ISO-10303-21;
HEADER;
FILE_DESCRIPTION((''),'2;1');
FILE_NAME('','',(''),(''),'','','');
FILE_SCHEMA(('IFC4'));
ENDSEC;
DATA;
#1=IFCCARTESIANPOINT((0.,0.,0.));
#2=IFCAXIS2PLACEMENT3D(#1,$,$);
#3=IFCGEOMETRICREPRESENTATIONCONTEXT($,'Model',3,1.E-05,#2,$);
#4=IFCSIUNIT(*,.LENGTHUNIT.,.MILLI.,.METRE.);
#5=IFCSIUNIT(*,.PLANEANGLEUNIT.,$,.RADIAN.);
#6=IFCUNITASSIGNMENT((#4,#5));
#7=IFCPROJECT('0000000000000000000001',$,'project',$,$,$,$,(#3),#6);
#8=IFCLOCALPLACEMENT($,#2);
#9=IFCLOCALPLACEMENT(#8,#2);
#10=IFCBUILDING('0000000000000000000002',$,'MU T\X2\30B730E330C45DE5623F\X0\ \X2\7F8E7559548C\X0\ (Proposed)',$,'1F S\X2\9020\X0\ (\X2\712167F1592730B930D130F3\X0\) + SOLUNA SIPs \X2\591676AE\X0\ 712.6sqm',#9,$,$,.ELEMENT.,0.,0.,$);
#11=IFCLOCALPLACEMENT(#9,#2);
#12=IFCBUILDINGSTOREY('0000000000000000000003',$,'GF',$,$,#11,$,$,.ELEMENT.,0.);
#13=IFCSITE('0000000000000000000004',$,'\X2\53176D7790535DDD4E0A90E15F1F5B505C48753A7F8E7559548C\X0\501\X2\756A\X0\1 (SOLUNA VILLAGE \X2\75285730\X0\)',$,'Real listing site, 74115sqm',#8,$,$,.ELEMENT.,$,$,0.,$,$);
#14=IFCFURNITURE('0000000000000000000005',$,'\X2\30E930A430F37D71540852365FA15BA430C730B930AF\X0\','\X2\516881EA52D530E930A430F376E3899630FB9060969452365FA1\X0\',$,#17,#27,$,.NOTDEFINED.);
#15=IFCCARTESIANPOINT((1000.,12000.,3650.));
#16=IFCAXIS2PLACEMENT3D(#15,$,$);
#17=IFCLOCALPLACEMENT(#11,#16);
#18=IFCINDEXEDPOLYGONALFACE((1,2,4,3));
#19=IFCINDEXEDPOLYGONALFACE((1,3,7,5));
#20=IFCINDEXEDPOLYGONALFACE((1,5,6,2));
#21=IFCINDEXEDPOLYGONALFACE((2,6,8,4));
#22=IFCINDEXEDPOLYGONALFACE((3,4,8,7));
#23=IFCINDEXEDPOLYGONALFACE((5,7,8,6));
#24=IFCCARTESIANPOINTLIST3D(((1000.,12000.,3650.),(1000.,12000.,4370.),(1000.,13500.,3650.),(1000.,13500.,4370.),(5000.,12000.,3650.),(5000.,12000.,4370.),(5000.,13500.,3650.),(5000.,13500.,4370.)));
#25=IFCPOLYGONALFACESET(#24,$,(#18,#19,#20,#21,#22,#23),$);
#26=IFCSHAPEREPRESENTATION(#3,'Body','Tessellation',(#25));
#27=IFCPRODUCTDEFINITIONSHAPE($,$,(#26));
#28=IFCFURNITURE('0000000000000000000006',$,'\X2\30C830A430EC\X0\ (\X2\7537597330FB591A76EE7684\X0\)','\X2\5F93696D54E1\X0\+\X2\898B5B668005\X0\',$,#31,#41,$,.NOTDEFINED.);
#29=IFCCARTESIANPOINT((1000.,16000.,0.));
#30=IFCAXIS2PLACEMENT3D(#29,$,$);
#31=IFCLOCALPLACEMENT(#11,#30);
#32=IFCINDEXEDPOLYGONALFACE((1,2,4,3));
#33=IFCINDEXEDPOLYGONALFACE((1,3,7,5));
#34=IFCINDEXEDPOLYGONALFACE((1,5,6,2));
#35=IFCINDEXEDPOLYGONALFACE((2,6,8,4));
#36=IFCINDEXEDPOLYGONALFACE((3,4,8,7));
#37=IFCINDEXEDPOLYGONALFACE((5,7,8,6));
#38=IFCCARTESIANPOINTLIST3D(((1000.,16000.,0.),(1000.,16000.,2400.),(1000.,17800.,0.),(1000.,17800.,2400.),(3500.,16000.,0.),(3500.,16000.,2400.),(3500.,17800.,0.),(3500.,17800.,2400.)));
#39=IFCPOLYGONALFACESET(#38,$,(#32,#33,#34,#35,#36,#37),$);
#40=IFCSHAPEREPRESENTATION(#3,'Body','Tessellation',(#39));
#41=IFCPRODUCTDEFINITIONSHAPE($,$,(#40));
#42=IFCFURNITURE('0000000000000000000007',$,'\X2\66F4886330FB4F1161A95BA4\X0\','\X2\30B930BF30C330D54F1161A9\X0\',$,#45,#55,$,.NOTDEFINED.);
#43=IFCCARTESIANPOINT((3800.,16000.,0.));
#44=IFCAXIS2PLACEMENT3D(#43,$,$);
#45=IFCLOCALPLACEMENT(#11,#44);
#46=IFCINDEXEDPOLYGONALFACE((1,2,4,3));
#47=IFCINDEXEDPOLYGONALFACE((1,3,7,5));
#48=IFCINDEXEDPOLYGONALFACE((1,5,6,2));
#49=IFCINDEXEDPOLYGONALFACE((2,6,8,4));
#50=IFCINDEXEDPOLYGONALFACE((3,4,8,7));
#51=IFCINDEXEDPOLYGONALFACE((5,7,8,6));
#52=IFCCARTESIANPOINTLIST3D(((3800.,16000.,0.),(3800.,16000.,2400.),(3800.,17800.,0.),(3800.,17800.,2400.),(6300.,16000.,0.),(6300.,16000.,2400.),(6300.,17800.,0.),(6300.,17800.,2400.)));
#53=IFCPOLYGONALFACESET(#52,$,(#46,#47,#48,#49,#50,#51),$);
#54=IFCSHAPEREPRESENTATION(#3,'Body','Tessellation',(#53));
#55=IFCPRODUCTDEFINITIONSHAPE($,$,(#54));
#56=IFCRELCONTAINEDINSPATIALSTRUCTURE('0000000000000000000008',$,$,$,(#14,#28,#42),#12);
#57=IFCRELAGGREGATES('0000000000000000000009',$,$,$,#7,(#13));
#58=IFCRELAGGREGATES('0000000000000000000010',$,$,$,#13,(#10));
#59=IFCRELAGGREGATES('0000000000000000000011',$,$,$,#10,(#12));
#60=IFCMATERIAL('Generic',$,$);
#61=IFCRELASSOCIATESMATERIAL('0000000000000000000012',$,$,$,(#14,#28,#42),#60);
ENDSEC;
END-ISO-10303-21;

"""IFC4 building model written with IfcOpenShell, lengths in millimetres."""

from ifc_helpers import new_model, si_unit, frame, frame_2d, origin, place, context, project, spatial, rectangle, extrude, material, element, save


model = new_model("IFC4")

# Units and contexts
model_context = context("Model", 3, precision=1e-05, world=origin())
ifc_project = project(units=[si_unit("LENGTHUNIT", "METRE", prefix="MILLI"), si_unit("PLANEANGLEUNIT", "RADIAN")], contexts=[model_context])

# Site, building, storey
site_placement = place(None, origin())
site = spatial("IfcSite", under=ifc_project, at=site_placement, Name="北海道川上郡弟子屈町美留和501番1 (SOLUNA VILLAGE 用地)", ObjectType="Real listing site, 74115sqm", CompositionType="ELEMENT", RefElevation=0.0)
building_placement = place(site_placement, origin())
building = spatial("IfcBuilding", under=site, at=building_placement, Name="MU Tシャツ工房 美留和 (Proposed)", ObjectType="1F S造 (無柱大スパン) + SOLUNA SIPs 外皮 712.6sqm", CompositionType="ELEMENT", ElevationOfRefHeight=0.0, ElevationOfTerrain=0.0)
storey_placement = place(building_placement, origin())
storey = spatial("IfcBuildingStorey", under=building, at=storey_placement, Name="GF", CompositionType="ELEMENT", Elevation=0.0)

# Shared definitions
ifc_material_1 = material(Name="Generic")

# Furniture
furniture_1_placement = place(storey_placement, frame((1000.0, 12000.0, 3650.0)))
element("IfcFurniture", 1, at=furniture_1_placement, inside=storey, material=ifc_material_1, Name="ライン統合制御室デスク", Description="全自動ライン監視・遠隔制御", PredefinedType="NOTDEFINED", context=model_context, shape_type="SweptSolid", body=[
    extrude(rectangle(XDim=4000.0, YDim=1500.0, at=frame_2d((2000.0, 750.0))), frame((1000.0, 12000.0, 3650.0)), (0.0, 0.0, 1.0), 720.0),
])
furniture_2_placement = place(storey_placement, frame((1000.0, 16000.0, 0.0)))
element("IfcFurniture", 2, at=furniture_2_placement, inside=storey, material=ifc_material_1, Name="トイレ (男女・多目的)", Description="従業員+見学者", PredefinedType="NOTDEFINED", context=model_context, shape_type="SweptSolid", body=[
    extrude(rectangle(XDim=2500.0, YDim=1800.0, at=frame_2d((1250.0, 900.0))), frame((1000.0, 16000.0, 0.0)), (0.0, 0.0, 1.0), 2400.0),
])
furniture_3_placement = place(storey_placement, frame((3800.0, 16000.0, 0.0)))
element("IfcFurniture", 3, at=furniture_3_placement, inside=storey, material=ifc_material_1, Name="更衣・休憩室", Description="スタッフ休憩", PredefinedType="NOTDEFINED", context=model_context, shape_type="SweptSolid", body=[
    extrude(rectangle(XDim=2500.0, YDim=1800.0, at=frame_2d((1250.0, 900.0))), frame((3800.0, 16000.0, 0.0)), (0.0, 0.0, 1.0), 2400.0),
])

save(model, "model.ifc")
